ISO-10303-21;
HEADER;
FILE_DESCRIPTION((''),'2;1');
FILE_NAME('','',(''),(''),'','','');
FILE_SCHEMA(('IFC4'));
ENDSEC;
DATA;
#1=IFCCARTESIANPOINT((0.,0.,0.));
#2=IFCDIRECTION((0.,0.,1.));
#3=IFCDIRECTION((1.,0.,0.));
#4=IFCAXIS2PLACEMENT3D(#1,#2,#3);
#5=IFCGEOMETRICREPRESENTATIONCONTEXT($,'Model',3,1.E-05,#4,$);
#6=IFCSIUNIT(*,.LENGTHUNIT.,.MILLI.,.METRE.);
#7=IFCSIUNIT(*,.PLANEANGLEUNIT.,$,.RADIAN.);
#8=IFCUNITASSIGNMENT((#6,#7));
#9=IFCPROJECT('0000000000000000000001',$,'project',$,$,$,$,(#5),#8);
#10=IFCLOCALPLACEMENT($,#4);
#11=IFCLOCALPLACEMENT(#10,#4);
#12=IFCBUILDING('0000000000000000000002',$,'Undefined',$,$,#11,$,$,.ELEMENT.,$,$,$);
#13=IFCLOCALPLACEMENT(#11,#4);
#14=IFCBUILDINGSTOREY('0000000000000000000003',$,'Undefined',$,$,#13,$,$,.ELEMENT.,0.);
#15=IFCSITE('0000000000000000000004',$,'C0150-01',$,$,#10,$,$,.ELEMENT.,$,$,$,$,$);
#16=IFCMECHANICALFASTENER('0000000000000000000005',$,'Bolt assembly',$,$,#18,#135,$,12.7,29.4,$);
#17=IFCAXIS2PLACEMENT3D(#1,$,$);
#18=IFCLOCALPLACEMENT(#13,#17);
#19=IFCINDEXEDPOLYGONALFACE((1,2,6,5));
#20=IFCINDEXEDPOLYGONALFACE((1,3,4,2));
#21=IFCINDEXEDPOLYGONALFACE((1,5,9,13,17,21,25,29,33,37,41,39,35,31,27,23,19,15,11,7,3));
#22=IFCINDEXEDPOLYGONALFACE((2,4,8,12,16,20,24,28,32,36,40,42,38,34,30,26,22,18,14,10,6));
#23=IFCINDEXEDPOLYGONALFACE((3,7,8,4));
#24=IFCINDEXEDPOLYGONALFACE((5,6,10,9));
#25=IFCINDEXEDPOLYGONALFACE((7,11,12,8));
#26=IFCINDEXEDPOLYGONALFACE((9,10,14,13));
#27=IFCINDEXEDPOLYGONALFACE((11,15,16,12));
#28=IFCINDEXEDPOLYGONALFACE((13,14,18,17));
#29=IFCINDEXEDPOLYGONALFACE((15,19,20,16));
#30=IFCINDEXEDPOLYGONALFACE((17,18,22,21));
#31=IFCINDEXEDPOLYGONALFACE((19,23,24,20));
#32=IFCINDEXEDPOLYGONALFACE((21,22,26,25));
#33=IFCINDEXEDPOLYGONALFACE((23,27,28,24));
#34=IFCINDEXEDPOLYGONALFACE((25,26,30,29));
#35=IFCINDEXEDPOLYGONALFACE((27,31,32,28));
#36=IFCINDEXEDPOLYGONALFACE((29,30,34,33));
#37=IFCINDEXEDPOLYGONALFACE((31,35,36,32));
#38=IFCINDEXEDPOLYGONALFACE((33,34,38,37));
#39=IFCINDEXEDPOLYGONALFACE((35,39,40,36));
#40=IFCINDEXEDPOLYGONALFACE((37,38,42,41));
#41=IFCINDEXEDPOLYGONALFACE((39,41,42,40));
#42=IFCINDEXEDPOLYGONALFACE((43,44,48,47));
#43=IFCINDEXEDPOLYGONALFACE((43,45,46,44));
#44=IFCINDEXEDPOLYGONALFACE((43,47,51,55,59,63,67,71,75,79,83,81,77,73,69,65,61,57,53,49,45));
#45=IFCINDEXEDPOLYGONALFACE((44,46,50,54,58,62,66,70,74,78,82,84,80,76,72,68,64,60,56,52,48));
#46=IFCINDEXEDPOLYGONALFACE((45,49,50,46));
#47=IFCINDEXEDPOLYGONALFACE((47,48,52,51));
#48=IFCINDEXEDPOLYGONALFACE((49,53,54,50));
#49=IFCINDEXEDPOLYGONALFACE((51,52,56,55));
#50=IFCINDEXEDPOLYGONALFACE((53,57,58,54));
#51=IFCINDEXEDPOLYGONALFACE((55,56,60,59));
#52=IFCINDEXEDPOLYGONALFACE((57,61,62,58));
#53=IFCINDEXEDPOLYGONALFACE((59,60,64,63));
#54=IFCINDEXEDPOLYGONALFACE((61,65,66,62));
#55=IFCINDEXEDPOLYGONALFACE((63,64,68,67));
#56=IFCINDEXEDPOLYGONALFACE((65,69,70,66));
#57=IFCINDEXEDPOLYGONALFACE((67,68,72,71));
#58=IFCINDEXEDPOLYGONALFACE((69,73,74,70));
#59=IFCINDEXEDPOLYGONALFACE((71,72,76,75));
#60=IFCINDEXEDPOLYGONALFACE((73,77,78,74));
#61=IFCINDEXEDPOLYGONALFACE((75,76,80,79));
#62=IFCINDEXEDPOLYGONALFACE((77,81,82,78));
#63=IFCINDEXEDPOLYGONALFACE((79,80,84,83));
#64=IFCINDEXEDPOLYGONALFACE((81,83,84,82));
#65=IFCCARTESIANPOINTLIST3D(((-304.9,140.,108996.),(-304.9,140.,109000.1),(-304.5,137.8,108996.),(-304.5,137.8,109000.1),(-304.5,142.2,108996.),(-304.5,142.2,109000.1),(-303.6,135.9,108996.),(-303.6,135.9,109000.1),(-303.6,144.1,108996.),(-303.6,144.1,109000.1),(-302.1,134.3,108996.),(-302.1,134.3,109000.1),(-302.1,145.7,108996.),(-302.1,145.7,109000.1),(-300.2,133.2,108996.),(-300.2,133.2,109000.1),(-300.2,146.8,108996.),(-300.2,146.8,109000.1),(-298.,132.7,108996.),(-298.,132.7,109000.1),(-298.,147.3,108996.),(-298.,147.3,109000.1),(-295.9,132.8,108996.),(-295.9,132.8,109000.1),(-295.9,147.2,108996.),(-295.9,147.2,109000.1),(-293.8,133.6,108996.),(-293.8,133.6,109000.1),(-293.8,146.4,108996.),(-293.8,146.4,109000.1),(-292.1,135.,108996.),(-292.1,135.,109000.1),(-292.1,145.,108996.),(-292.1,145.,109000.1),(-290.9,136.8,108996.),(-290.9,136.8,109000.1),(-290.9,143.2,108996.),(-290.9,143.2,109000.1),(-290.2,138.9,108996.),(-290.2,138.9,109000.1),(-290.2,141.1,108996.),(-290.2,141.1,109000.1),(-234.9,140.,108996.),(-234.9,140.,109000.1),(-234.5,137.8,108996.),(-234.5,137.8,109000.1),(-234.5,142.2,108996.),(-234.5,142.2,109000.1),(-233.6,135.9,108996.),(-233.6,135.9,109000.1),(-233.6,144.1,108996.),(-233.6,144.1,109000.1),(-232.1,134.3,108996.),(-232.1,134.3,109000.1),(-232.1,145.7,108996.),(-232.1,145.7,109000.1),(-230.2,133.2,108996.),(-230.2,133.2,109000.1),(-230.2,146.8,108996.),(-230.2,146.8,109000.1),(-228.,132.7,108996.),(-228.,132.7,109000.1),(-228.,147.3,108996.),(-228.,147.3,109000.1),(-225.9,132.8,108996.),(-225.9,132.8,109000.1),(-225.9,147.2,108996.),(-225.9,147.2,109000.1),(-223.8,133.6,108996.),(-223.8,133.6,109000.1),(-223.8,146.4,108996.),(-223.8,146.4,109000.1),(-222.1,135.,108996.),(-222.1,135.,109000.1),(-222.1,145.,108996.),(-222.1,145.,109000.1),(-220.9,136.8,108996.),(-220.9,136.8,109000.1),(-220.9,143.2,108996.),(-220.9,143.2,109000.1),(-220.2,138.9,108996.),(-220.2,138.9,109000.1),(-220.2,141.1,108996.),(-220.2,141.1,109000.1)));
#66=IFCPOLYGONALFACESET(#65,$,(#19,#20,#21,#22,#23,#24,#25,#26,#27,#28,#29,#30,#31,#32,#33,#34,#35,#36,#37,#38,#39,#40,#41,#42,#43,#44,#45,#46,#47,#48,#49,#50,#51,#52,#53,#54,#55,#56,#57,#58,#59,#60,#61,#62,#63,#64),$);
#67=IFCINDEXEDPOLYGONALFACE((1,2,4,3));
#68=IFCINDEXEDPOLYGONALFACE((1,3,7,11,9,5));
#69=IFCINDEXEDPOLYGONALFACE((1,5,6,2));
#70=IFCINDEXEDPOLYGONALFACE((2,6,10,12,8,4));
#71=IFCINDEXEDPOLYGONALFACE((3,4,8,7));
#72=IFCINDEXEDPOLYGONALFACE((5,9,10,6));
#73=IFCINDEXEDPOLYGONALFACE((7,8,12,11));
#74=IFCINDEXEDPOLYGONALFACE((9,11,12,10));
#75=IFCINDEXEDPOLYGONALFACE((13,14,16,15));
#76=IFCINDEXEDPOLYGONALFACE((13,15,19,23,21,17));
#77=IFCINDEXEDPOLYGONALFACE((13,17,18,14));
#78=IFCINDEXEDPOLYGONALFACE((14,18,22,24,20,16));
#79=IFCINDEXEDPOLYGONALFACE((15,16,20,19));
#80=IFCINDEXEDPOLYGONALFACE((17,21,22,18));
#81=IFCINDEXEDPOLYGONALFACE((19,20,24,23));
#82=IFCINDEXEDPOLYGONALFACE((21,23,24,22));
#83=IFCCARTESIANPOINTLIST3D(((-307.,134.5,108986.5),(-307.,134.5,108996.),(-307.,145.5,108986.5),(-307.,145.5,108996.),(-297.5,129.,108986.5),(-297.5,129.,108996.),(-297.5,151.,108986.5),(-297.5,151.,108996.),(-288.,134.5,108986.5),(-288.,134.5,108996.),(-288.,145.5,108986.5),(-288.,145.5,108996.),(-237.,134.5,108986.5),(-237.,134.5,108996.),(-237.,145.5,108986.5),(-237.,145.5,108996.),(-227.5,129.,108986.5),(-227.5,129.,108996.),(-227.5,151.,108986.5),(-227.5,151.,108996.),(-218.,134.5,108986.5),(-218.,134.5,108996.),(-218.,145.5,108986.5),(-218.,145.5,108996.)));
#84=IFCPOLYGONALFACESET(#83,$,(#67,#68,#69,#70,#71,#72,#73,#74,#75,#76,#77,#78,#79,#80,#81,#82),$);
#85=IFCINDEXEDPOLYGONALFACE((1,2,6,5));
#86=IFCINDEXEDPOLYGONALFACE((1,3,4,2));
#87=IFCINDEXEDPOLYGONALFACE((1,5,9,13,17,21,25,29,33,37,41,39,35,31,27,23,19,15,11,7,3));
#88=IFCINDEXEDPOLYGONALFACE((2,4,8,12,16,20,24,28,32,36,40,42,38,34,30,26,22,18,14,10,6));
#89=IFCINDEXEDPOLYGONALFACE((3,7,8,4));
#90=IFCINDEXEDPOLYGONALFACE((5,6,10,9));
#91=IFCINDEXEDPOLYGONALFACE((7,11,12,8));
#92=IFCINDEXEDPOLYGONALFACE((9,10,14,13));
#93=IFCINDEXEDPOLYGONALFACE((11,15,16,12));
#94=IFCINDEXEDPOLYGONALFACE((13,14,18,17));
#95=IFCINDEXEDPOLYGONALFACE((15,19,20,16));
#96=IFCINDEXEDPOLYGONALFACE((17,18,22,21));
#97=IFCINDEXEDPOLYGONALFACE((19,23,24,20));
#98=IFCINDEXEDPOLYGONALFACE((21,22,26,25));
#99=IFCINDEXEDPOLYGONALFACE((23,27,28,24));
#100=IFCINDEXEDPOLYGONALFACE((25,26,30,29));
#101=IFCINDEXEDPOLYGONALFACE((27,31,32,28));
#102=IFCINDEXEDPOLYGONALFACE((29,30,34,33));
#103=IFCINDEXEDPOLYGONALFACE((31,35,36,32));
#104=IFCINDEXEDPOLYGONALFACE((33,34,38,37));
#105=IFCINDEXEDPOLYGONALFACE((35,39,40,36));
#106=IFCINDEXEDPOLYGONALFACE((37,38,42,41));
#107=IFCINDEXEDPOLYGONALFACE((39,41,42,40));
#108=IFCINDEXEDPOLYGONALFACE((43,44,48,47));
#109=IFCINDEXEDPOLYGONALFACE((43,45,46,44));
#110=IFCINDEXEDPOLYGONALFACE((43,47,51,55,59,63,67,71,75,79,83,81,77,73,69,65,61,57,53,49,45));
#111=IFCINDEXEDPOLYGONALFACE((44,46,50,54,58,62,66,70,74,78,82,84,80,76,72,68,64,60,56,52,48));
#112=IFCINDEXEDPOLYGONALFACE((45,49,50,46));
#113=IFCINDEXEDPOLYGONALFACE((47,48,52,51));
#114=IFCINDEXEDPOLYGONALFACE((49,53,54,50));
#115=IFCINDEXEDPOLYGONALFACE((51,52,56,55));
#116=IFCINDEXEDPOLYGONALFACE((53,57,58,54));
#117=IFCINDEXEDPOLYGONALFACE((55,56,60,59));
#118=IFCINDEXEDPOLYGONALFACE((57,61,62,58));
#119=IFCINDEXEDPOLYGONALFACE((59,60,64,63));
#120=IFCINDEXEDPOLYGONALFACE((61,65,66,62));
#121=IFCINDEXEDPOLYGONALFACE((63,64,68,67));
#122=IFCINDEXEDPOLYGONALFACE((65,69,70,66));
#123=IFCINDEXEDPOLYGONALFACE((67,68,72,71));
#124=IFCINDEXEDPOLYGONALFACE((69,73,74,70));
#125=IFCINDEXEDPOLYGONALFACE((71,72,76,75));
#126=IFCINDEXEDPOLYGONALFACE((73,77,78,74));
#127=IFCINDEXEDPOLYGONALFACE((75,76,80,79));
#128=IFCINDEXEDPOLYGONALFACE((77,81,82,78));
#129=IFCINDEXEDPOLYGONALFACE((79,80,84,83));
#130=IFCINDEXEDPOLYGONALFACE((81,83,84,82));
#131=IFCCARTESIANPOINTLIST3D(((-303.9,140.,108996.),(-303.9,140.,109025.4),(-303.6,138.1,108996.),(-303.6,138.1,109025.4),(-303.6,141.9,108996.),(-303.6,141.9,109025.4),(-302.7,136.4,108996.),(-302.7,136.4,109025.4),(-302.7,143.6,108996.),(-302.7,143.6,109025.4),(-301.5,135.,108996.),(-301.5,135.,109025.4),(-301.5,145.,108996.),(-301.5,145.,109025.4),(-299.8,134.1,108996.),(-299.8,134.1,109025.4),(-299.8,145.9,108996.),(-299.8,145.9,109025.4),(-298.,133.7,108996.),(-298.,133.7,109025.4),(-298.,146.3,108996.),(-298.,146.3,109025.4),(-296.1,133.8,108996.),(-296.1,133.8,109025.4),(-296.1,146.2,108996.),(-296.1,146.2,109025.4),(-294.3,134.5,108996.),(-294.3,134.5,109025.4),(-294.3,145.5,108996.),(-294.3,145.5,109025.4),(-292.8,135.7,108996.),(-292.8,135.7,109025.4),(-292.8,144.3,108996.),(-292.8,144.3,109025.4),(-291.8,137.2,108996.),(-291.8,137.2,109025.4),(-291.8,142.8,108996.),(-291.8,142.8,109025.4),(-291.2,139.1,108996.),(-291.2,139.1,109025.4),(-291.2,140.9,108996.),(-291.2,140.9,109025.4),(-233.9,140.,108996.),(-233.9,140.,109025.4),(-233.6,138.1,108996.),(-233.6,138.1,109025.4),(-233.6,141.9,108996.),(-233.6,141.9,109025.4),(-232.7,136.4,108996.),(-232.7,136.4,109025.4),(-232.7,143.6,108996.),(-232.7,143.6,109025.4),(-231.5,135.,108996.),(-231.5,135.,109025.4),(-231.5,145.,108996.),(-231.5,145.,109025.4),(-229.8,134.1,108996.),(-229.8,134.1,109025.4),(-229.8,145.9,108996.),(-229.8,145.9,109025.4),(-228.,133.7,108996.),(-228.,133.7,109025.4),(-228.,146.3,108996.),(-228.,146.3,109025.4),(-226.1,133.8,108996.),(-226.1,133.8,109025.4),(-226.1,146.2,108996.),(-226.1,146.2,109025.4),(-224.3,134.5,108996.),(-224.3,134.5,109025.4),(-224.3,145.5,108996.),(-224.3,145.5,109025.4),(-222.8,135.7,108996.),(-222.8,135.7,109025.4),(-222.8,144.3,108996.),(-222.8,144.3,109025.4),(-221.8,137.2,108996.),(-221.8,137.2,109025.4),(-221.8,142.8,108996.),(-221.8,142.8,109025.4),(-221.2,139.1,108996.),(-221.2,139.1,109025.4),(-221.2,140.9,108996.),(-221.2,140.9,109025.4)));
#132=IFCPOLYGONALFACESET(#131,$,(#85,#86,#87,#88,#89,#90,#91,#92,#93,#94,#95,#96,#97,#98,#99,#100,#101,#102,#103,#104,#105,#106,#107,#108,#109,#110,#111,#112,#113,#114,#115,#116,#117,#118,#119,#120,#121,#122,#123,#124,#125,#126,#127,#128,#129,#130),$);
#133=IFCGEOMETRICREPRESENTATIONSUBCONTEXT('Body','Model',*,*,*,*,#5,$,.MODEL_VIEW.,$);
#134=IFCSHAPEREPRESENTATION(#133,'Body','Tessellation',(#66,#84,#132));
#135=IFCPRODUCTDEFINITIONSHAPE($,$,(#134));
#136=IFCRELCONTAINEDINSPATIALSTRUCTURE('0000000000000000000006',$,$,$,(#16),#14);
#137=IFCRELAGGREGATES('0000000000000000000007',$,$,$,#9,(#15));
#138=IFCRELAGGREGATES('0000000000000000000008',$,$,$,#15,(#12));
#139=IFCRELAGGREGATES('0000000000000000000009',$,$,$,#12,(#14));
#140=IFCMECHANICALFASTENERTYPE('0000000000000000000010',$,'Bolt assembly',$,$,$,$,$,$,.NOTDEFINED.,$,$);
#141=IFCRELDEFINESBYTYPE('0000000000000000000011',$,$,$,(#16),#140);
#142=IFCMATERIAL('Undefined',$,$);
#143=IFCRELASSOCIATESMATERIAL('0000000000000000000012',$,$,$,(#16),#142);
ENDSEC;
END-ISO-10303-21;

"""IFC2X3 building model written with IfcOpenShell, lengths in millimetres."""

from ifc_helpers import new_model, si_unit, frame, origin_with_axes, origin_2d_with_axis, place, context, subcontext, project, spatial, polyline, circle, outline, extrude, source, transform, mapped, material, type_object, element, save


model = new_model("IFC2X3")

# Units and contexts
model_context = context("Model", 3, precision=1e-05, world=origin_with_axes())
body_context = subcontext(model_context, "Body", "Model", "MODEL_VIEW")
ifc_project = project(units=[si_unit("LENGTHUNIT", "METRE", prefix="MILLI"), si_unit("PLANEANGLEUNIT", "RADIAN")], contexts=[model_context])

# Site, building, storey
site_placement = place(None, origin_with_axes())
site = spatial("IfcSite", under=ifc_project, at=site_placement, Name="C0150-01", CompositionType="ELEMENT")
building_placement = place(site_placement, origin_with_axes())
building = spatial("IfcBuilding", under=site, at=building_placement, Name="Undefined", CompositionType="ELEMENT")
storey_placement = place(building_placement, origin_with_axes())
storey = spatial("IfcBuildingStorey", under=building, at=storey_placement, Name="Undefined", CompositionType="ELEMENT", Elevation=0.0)

# Mechanical fastener
ifc_material_1 = material(Name="Undefined")
mechanical_fastener_type = type_object("IfcMechanicalFastenerType", Name="Bolt assembly")
shared_shape_1 = source(origin_with_axes(), body_context, "Body", "SweptSolid", [
    extrude(circle(Radius=7.3, at=origin_2d_with_axis()), frame((0.0, -4.0, 0.0), z_axis=(0.0, 1.0, 0.0), x_axis=(1.0, 0.0, 0.0)), (0.0, 0.0, 1.0), 4.1),
    extrude(outline(polyline([(9.5, -5.5), (9.5, 5.5), (0.0, 11.0), (-9.5, 5.5), (-9.5, -5.5), (0.0, -11.0), (9.5, -5.5)])), frame((0.0, -13.5, 0.0), z_axis=(0.0, 1.0, 0.0), x_axis=(1.0, 0.0, 0.0)), (0.0, 0.0, 1.0), 9.5),
    extrude(circle(Radius=6.3, at=origin_2d_with_axis()), frame((0.0, -4.0, 0.0), z_axis=(0.0, 1.0, 0.0), x_axis=(1.0, 0.0, 0.0)), (0.0, 0.0, 1.0), 29.4),
])
for number, where, z_axis, x_axis, name in (
    (1, (-227.5, 140.0, 109000.0), (0.0, 1.0, 0.0), (-1.0, 0.0, 0.0), "Bolt assembly"),
):
    element("IfcMechanicalFastener", number, at=place(storey_placement, frame(where, z_axis=z_axis, x_axis=x_axis)), inside=storey, type_object=mechanical_fastener_type, material=ifc_material_1, Name=name, NominalDiameter=12.7, NominalLength=29.4, context=body_context, shape_type="MappedRepresentation", body=[
        mapped(shared_shape_1, transform((0.0, 0.0, 0.0))),
        mapped(shared_shape_1, transform((70.0, 0.0, 0.0))),
    ])

save(model, "model.ifc")
